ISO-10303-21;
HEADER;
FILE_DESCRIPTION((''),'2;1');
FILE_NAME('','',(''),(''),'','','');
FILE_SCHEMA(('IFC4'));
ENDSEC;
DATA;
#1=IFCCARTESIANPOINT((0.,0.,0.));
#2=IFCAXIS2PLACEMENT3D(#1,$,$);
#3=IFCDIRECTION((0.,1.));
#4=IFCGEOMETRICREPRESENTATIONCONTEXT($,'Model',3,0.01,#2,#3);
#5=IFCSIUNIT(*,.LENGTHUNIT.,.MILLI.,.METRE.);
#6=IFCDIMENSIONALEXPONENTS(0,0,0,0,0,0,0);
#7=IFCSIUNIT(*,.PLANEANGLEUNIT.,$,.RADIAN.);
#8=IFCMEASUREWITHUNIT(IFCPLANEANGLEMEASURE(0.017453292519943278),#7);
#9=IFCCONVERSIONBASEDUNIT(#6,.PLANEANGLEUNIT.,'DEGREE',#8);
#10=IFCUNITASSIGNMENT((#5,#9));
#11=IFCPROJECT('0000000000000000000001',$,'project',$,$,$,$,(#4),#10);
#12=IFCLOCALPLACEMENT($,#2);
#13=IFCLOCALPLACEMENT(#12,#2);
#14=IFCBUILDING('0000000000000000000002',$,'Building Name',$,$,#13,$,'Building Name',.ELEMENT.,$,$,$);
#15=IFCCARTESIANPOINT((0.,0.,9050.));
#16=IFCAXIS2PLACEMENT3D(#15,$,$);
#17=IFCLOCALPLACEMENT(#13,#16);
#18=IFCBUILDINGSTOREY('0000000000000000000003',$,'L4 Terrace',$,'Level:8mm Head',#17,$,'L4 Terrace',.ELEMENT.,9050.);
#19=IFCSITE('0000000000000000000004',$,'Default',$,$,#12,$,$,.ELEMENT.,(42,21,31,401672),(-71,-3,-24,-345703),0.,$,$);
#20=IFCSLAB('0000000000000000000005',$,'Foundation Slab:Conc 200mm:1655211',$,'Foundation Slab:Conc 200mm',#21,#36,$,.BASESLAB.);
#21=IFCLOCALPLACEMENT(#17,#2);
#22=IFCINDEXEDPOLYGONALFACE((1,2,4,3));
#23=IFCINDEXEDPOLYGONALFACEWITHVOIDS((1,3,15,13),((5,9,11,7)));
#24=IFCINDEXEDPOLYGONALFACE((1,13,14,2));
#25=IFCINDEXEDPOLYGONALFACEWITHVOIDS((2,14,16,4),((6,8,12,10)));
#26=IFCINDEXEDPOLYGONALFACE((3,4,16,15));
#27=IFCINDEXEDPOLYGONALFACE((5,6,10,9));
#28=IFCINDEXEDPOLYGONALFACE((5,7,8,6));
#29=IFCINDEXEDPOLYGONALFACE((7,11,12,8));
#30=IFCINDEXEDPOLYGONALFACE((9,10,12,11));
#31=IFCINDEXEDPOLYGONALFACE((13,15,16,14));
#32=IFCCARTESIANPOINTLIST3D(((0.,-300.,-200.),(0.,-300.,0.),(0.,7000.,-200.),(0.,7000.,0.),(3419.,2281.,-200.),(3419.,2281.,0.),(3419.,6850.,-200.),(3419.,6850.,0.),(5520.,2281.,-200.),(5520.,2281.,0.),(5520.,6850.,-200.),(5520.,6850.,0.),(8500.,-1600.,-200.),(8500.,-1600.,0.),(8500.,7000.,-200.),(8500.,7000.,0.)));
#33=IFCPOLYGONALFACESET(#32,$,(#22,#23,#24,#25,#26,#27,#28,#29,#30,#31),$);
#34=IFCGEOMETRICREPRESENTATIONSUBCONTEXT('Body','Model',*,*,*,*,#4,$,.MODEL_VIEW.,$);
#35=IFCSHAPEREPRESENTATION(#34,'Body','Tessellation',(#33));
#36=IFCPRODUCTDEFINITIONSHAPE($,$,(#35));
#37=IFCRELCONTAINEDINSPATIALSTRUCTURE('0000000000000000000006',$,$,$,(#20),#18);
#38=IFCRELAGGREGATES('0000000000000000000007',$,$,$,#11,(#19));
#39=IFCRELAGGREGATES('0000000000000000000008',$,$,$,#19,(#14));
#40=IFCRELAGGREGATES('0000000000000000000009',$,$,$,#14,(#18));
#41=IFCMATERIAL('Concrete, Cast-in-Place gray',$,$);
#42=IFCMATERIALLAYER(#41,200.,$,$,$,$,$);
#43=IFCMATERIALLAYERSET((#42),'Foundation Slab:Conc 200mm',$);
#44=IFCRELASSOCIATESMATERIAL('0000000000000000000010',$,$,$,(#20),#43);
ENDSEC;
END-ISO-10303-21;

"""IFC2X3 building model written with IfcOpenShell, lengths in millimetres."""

from ifc_helpers import new_model, entity, si_unit, converted_unit, direction, frame, frame_2d, origin, place, context, subcontext, project, spatial, polyline, rectangle, outline, extrude, material, layer, layer_set, layer_usage, element, save


model = new_model("IFC2X3")

# Units and contexts
model_context = context("Model", 3, precision=0.01, world=origin(), true_north=direction((0.0, 1.0)))
body_context = subcontext(model_context, "Body", "Model", "MODEL_VIEW")
ifc_project = project(units=[si_unit("LENGTHUNIT", "METRE", prefix="MILLI"), converted_unit("PLANEANGLEUNIT", "DEGREE", entity("IfcPlaneAngleMeasure", 0.017453292519943278), si_unit("PLANEANGLEUNIT", "RADIAN"), dimensions=[0, 0, 0, 0, 0, 0, 0])], contexts=[model_context])

# Site, building, storey
site_placement = place(None, origin())
site = spatial("IfcSite", under=ifc_project, at=site_placement, Name="Default", CompositionType="ELEMENT", RefLatitude=(42, 21, 31, 401672), RefLongitude=(-71, -3, -24, -345703), RefElevation=0.0)
building_placement = place(site_placement, origin())
building = spatial("IfcBuilding", under=site, at=building_placement, Name="Building Name", LongName="Building Name", CompositionType="ELEMENT")
storey_placement = place(building_placement, frame((0.0, 0.0, 9050.0)))
storey = spatial("IfcBuildingStorey", under=building, at=storey_placement, Name="L4 Terrace", ObjectType="Level:8mm Head", LongName="L4 Terrace", CompositionType="ELEMENT", Elevation=9050.0)

# Slab, opening
ifc_material = material(Name="Concrete, Cast-in-Place gray")
ifc_layer = layer(ifc_material, 200.0)
ifc_layer_set = layer_set([ifc_layer], Name="Foundation Slab:Conc 200mm")
ifc_layer_usage = layer_usage(ifc_layer_set, "AXIS3", "POSITIVE", 0.0)
slab_placement = place(storey_placement, frame((0.0, -1600.0, -200.0)))
slab = element("IfcSlab", 1, at=slab_placement, inside=storey, material=ifc_layer_usage, Name="Foundation Slab:Conc 200mm:1655211", ObjectType="Foundation Slab:Conc 200mm", PredefinedType="BASESLAB", context=body_context, shape_type="SweptSolid", body=[
    extrude(outline(polyline([(-4250.0, 4300.0), (-4250.0, -4300.0), (4250.0, -3000.0), (4250.0, 4300.0), (-4250.0, 4300.0)])), frame((4250.0, 4300.0, 200.0), z_axis=(0.0, 0.0, -1.0), x_axis=(-1.0, 0.0, 0.0)), (0.0, 0.0, 1.0), 200.0),
])
opening_placement = place(slab_placement, origin())
element("IfcOpeningElement", 2, at=opening_placement, cuts=slab, ObjectType="Opening", context=body_context, shape_type="SweptSolid", body=[
    extrude(rectangle(XDim=2101.0, YDim=4569.0, at=frame_2d((0.0, 0.0), x_axis=(1.0, 0.0))), frame((4469.5, 6165.5, 200.0), z_axis=(0.0, 0.0, -1.0), x_axis=(-1.0, 0.0, 0.0)), (0.0, 0.0, 1.0), 200.0),
])

save(model, "model.ifc")
